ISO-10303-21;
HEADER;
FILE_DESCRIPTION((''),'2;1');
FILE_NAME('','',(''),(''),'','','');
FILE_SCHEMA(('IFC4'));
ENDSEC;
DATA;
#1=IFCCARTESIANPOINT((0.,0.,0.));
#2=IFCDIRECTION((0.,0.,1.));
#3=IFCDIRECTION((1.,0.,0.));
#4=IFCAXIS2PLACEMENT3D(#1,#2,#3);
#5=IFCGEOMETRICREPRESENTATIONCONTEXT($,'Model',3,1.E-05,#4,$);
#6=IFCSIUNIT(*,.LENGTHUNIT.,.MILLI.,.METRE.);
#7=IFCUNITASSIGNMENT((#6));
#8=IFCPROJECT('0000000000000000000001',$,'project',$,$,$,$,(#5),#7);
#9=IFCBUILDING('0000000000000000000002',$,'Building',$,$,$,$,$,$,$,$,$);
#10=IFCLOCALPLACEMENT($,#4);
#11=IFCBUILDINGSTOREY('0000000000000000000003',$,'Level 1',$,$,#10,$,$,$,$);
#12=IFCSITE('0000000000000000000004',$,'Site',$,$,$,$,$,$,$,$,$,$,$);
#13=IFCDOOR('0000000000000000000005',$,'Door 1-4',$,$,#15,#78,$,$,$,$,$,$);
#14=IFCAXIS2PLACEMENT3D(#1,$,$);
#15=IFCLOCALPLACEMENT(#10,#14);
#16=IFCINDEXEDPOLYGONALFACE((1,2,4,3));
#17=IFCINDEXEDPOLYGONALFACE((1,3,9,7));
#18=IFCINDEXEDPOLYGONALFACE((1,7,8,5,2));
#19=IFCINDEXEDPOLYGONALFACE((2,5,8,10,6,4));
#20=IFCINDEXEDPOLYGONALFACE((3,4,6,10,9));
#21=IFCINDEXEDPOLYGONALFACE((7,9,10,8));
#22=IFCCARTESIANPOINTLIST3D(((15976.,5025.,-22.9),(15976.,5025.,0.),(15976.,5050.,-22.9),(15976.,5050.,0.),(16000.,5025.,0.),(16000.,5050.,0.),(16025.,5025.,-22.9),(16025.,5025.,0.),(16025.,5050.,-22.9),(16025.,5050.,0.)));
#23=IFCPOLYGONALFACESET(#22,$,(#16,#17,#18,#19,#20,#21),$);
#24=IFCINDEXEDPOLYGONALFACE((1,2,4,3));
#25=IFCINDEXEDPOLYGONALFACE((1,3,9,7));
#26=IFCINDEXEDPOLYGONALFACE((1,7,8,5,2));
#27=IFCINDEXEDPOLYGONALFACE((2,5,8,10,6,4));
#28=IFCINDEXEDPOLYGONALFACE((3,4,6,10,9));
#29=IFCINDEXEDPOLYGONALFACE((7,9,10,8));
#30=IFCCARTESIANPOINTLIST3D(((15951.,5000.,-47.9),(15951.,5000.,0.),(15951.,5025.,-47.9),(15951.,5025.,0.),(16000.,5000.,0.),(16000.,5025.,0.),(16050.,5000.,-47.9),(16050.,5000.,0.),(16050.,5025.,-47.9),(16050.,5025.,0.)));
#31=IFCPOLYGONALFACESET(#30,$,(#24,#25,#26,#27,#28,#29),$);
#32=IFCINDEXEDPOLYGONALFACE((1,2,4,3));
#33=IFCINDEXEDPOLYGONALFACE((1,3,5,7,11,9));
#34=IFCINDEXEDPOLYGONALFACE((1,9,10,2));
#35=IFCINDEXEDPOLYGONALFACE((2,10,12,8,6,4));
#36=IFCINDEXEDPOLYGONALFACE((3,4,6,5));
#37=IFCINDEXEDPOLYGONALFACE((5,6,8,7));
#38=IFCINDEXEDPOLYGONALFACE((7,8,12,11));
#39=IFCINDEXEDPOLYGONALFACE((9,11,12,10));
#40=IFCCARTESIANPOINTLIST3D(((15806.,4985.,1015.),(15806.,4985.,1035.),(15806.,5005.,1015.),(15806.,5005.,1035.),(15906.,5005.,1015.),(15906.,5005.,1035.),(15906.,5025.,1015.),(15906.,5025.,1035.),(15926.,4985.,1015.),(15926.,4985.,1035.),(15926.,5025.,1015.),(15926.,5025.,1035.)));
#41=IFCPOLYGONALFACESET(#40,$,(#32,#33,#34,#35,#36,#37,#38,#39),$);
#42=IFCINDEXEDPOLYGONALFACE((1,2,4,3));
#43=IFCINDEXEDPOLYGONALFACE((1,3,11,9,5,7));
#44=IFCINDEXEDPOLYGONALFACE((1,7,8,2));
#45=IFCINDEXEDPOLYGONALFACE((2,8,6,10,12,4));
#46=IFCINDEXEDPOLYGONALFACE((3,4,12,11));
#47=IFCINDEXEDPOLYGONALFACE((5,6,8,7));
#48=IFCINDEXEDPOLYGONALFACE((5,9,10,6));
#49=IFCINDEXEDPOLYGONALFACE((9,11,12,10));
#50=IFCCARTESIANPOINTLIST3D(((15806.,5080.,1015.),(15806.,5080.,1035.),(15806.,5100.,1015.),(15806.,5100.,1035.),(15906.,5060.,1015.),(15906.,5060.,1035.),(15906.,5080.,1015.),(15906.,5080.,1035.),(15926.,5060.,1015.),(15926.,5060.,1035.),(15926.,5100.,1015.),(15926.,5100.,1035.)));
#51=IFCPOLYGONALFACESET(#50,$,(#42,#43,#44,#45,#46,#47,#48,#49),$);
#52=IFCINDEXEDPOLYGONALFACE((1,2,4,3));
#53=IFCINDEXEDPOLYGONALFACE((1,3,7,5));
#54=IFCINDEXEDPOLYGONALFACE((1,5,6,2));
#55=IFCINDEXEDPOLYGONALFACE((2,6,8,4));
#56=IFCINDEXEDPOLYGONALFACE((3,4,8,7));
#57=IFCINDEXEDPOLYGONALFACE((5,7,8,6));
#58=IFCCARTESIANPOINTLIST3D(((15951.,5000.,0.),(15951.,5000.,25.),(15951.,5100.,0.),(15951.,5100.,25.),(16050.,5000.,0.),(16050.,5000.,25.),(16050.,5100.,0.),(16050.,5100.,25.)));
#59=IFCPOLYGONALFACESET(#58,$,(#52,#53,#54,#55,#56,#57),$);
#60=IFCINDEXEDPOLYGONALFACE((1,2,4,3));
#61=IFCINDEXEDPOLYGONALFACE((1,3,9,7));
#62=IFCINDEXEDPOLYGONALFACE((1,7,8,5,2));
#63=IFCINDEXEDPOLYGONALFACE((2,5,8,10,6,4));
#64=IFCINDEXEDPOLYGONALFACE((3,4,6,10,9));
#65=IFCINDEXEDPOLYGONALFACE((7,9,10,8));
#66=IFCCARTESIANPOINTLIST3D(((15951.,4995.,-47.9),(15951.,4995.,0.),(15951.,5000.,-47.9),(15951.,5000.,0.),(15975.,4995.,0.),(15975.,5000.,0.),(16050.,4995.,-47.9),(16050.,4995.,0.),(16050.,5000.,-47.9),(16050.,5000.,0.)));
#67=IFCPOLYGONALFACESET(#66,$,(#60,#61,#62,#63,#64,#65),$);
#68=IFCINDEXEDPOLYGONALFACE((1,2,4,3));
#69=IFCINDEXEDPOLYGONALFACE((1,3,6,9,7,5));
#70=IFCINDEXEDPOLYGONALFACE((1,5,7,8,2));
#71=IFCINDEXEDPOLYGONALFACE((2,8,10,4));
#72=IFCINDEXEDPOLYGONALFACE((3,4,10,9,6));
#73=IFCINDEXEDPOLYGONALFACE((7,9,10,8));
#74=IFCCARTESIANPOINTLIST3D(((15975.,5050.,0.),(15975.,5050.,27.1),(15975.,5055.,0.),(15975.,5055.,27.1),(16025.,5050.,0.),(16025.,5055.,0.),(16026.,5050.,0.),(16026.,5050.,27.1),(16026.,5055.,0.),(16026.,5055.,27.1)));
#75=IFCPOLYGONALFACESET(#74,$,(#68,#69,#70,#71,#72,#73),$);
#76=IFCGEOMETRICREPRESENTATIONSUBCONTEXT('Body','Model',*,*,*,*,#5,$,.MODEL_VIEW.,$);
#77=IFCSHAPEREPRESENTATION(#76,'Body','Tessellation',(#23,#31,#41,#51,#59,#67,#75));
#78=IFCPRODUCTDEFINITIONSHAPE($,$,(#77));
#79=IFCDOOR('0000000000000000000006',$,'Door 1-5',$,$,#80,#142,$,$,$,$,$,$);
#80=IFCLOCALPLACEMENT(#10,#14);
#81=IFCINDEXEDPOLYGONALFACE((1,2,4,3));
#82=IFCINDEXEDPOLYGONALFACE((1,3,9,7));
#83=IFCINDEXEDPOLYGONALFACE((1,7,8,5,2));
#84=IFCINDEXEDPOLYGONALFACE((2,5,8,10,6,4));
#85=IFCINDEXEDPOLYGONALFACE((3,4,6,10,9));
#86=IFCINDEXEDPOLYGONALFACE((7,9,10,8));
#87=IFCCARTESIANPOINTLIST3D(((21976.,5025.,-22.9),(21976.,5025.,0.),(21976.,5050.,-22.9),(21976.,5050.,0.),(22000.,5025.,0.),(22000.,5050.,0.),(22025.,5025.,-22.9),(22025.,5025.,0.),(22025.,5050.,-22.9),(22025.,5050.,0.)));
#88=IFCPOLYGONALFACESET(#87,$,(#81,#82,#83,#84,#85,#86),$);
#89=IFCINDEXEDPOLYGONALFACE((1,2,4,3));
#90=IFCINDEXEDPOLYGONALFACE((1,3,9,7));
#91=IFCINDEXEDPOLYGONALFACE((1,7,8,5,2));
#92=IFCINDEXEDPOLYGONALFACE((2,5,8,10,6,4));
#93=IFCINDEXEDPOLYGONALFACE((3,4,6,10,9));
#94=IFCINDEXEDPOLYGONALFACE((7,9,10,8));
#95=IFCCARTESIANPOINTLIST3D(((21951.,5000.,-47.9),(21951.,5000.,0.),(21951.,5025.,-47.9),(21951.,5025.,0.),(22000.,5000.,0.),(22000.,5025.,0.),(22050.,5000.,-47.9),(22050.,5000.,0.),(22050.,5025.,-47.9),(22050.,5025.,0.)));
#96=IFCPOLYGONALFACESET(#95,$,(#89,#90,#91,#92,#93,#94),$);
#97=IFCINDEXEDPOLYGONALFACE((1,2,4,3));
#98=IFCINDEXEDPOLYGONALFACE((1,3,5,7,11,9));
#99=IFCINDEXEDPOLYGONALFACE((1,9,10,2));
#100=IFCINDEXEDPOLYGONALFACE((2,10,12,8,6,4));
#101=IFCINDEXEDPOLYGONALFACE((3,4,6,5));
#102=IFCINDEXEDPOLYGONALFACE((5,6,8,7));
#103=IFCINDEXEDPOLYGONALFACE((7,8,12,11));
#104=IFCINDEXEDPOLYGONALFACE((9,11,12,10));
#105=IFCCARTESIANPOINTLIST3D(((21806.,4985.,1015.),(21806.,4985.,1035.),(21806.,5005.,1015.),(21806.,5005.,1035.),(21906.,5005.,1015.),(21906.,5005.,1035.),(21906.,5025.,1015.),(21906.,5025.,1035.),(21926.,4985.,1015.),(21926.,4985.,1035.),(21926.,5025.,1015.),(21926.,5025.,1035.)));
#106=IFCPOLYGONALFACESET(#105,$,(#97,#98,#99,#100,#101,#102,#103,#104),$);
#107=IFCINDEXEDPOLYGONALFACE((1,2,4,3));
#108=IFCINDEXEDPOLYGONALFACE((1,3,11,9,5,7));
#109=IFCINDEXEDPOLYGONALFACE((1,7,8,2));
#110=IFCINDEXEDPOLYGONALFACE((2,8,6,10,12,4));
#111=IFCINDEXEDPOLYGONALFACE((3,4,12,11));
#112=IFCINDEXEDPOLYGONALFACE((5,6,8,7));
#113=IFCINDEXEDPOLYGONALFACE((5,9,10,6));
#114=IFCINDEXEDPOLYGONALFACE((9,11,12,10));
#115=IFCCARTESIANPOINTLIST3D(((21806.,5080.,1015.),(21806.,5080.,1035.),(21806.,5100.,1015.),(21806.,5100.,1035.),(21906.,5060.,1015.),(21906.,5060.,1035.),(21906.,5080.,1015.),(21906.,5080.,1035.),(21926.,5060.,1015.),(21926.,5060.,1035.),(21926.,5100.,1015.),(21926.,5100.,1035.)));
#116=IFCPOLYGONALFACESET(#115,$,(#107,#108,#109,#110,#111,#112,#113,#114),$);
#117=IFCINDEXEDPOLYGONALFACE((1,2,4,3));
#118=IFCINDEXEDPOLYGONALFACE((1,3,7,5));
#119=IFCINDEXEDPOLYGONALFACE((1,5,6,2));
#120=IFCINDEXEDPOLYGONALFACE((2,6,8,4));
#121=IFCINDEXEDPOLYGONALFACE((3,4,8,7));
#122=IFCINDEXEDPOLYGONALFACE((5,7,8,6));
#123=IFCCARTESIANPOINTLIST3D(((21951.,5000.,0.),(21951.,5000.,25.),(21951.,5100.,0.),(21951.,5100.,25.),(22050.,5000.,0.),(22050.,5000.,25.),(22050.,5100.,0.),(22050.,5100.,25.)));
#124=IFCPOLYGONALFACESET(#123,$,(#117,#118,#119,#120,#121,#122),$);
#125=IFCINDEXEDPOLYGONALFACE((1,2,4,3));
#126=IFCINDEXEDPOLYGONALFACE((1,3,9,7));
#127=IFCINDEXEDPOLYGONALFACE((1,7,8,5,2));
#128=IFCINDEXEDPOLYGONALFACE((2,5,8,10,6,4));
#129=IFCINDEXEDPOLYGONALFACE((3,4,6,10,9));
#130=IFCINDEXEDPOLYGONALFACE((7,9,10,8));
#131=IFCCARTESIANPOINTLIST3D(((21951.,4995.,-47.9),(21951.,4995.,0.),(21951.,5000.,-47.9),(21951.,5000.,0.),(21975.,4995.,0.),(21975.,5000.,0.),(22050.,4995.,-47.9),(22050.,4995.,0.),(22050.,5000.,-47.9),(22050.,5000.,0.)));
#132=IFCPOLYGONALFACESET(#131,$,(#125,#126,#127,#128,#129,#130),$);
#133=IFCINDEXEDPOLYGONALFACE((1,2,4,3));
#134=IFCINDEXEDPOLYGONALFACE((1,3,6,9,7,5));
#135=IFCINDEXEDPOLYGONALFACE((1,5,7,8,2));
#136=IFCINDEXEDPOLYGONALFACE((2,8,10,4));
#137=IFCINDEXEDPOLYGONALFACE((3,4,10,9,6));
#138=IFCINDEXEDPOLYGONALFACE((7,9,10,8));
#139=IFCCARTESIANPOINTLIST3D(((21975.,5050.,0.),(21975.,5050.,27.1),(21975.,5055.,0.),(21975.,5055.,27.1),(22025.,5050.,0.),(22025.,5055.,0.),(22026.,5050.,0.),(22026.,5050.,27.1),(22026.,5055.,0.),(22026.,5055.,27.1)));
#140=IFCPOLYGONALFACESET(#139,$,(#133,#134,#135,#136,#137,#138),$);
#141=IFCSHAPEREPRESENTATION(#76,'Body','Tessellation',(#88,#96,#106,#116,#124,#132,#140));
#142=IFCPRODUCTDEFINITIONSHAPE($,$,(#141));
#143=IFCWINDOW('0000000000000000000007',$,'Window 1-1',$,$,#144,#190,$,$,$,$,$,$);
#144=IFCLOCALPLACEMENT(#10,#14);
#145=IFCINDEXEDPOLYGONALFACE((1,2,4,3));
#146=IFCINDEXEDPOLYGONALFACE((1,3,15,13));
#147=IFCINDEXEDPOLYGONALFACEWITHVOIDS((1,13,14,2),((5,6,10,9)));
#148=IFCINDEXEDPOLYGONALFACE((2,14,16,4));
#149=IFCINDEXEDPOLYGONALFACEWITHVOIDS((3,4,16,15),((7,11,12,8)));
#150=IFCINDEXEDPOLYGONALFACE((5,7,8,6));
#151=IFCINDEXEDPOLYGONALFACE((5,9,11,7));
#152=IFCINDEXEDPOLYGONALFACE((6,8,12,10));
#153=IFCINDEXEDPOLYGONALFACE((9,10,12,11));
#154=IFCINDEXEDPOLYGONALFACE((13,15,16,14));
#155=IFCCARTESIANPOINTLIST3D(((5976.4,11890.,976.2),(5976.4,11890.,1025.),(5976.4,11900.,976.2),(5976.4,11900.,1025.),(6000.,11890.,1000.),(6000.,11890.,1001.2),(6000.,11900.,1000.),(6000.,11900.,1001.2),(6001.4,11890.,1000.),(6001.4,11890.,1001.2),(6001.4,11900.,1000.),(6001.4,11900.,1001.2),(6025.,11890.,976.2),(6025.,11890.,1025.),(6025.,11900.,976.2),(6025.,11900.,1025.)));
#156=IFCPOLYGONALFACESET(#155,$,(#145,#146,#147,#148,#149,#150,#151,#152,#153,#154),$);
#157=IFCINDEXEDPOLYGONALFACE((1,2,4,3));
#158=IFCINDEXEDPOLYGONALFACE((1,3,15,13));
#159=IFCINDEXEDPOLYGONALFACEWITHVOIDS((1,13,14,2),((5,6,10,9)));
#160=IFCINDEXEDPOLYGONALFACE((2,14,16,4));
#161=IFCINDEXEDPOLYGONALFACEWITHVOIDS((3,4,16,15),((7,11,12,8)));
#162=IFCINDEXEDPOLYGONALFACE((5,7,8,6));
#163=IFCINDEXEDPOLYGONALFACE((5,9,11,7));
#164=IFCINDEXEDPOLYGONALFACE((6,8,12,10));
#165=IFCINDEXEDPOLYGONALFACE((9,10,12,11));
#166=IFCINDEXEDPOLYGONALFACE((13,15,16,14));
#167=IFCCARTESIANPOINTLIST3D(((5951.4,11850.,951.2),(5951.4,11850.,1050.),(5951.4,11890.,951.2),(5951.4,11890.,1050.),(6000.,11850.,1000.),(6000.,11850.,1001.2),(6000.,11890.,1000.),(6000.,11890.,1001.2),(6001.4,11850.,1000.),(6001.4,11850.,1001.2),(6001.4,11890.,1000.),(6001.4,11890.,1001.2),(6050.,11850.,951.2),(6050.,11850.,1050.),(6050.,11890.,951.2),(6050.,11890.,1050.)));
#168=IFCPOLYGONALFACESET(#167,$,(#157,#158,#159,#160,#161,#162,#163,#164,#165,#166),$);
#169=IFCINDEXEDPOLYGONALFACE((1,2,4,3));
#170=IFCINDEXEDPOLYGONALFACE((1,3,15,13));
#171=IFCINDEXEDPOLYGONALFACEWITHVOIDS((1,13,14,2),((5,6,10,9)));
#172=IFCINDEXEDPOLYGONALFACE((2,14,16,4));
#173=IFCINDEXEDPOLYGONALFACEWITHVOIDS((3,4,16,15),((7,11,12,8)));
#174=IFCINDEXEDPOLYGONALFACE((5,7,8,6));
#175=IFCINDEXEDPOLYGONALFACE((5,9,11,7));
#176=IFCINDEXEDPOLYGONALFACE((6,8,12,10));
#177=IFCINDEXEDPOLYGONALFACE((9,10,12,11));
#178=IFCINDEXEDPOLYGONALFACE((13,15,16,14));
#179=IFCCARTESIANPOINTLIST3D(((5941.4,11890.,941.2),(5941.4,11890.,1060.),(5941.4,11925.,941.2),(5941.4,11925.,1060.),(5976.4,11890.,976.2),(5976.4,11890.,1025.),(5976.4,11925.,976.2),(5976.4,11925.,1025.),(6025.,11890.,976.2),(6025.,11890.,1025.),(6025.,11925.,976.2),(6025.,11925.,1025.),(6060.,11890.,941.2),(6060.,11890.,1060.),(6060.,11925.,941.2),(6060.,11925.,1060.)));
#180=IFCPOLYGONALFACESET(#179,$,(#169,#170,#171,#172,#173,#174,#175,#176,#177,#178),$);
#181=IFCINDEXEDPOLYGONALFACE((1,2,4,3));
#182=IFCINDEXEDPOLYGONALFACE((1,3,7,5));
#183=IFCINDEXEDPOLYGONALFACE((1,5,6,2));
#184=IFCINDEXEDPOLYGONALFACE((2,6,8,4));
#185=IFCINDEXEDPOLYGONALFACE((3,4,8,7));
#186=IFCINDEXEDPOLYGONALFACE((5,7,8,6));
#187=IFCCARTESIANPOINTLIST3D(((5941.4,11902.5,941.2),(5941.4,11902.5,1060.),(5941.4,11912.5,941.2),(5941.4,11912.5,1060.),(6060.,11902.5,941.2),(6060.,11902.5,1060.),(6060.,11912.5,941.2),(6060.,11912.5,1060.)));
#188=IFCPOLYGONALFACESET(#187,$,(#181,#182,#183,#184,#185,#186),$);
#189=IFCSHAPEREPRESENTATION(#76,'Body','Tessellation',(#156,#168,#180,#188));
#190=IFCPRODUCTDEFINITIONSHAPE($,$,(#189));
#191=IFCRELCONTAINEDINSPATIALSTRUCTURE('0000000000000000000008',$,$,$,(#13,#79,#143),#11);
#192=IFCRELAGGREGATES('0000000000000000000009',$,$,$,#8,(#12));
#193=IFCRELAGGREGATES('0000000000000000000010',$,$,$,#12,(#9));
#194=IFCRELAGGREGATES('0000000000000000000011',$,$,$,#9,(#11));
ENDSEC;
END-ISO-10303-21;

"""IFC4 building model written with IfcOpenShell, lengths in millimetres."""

from ifc_helpers import new_model, si_unit, frame, origin_with_axes, place, context, subcontext, project, spatial, line, indexed_curve, outline, extrude, element, save


model = new_model("IFC4")

# Units and contexts
model_context = context("Model", 3, precision=1e-05, world=origin_with_axes())
body_context = subcontext(model_context, "Body", "Model", "MODEL_VIEW")
ifc_project = project(units=[si_unit("LENGTHUNIT", "METRE", prefix="MILLI")], contexts=[model_context])

# Site, building, storey
site = spatial("IfcSite", under=ifc_project, Name="Site")
building = spatial("IfcBuilding", under=site, Name="Building")
storey_placement = place(None, origin_with_axes())
storey = spatial("IfcBuildingStorey", under=building, at=storey_placement, Name="Level 1")

# Doors
door_1_placement = place(storey_placement, frame((16000.0, 5000.0, 0.0), z_axis=(0.0, 0.0, 1.0), x_axis=(1.0, 0.0, 0.0)))
element("IfcDoor", 1, at=door_1_placement, inside=storey, Name="Door 1-4", context=body_context, shape_type="SweptSolid", body=[
    extrude(outline(indexed_curve([(0.0, 0.0), (0.0, 2.1), (1.0, 2.1), (1.0, 0.0), (-24.0, 0.0), (-24.0, -22.9), (25.0, -22.9), (25.0, 0.0)], segments=[line(1, 2, 3, 4, 5, 6, 7, 8, 1)])), frame((0.0, 25.0, 0.0), z_axis=(0.0, -1.0, 0.0), x_axis=(1.0, 0.0, 0.0)), (0.0, 0.0, -1.0), 25.0),
    extrude(outline(indexed_curve([(0.0, 0.0), (0.0, 2.1), (1.0, 2.1), (1.0, 0.0), (-49.0, 0.0), (-49.0, -47.9), (50.0, -47.9), (50.0, 0.0)], segments=[line(1, 2, 3, 4, 5, 6, 7, 8, 1)])), frame((0.0, 0.0, 0.0), z_axis=(0.0, -1.0, 0.0), x_axis=(1.0, 0.0, 0.0)), (0.0, 0.0, -1.0), 25.0),
    extrude(outline(indexed_curve([(0.0, 0.0), (-49.0, 0.0), (-49.0, 35.0), (0.0, 35.0)], segments=[line(1, 2, 3, 4, 1)])), frame((25.0, 25.0, 25.0), z_axis=(0.0, 0.0, 1.0), x_axis=(1.0, 0.0, 0.0)), (0.0, 0.0, 1.0), -47.9),
    extrude(outline(indexed_curve([(0.0, 0.0), (0.0, -40.0), (-120.0, -40.0), (-120.0, -20.0), (-20.0, -20.0), (-20.0, 0.0)], segments=[line(1, 2, 3, 4, 5, 6, 1)])), frame((-74.0, 25.0, 1015.0), z_axis=(0.0, 0.0, 1.0), x_axis=(1.0, 0.0, 0.0)), (0.0, 0.0, 1.0), 20.0),
    extrude(outline(indexed_curve([(0.0, 0.0), (0.0, 40.0), (-120.0, 40.0), (-120.0, 20.0), (-20.0, 20.0), (-20.0, 0.0)], segments=[line(1, 2, 3, 4, 5, 6, 1)])), frame((-74.0, 60.0, 1015.0), z_axis=(0.0, 0.0, 1.0), x_axis=(1.0, 0.0, 0.0)), (0.0, 0.0, 1.0), 20.0),
    extrude(outline(indexed_curve([(0.0, 0.0), (-99.0, 0.0), (-99.0, 100.0), (0.0, 100.0)], segments=[line(1, 2, 3, 4, 1)])), frame((50.0, 0.0, 0.0), z_axis=(0.0, 0.0, 1.0), x_axis=(1.0, 0.0, 0.0)), (0.0, 0.0, 1.0), 25.0),
    extrude(outline(indexed_curve([(0.0, 0.0), (0.0, 27.1), (51.0, 27.1), (51.0, 0.0), (-24.0, 0.0), (-24.0, -47.9), (75.0, -47.9), (75.0, 0.0)], segments=[line(1, 2, 3, 4, 5, 6, 7, 8, 1)])), frame((-25.0, -5.0, 0.0), z_axis=(0.0, -1.0, 0.0), x_axis=(1.0, 0.0, 0.0)), (0.0, 0.0, -1.0), 5.0),
    extrude(outline(indexed_curve([(0.0, 0.0), (0.0, 27.1), (51.0, 27.1), (51.0, 0.0), (1.0, 0.0), (1.0, -22.9), (50.0, -22.9), (50.0, 0.0)], segments=[line(1, 2, 3, 4, 5, 6, 7, 8, 1)])), frame((-25.0, 50.0, 0.0), z_axis=(0.0, -1.0, 0.0), x_axis=(1.0, 0.0, 0.0)), (0.0, 0.0, -1.0), 5.0),
])
door_2_placement = place(storey_placement, frame((22000.0, 5000.0, 0.0), z_axis=(0.0, 0.0, 1.0), x_axis=(1.0, 0.0, 0.0)))
element("IfcDoor", 2, at=door_2_placement, inside=storey, Name="Door 1-5", context=body_context, shape_type="SweptSolid", body=[
    extrude(outline(indexed_curve([(0.0, 0.0), (0.0, 2.1), (1.0, 2.1), (1.0, 0.0), (-24.0, 0.0), (-24.0, -22.9), (25.0, -22.9), (25.0, 0.0)], segments=[line(1, 2, 3, 4, 5, 6, 7, 8, 1)])), frame((0.0, 25.0, 0.0), z_axis=(0.0, -1.0, 0.0), x_axis=(1.0, 0.0, 0.0)), (0.0, 0.0, -1.0), 25.0),
    extrude(outline(indexed_curve([(0.0, 0.0), (0.0, 2.1), (1.0, 2.1), (1.0, 0.0), (-49.0, 0.0), (-49.0, -47.9), (50.0, -47.9), (50.0, 0.0)], segments=[line(1, 2, 3, 4, 5, 6, 7, 8, 1)])), frame((0.0, 0.0, 0.0), z_axis=(0.0, -1.0, 0.0), x_axis=(1.0, 0.0, 0.0)), (0.0, 0.0, -1.0), 25.0),
    extrude(outline(indexed_curve([(0.0, 0.0), (-49.0, 0.0), (-49.0, 35.0), (0.0, 35.0)], segments=[line(1, 2, 3, 4, 1)])), frame((25.0, 25.0, 25.0), z_axis=(0.0, 0.0, 1.0), x_axis=(1.0, 0.0, 0.0)), (0.0, 0.0, 1.0), -47.9),
    extrude(outline(indexed_curve([(0.0, 0.0), (0.0, -40.0), (-120.0, -40.0), (-120.0, -20.0), (-20.0, -20.0), (-20.0, 0.0)], segments=[line(1, 2, 3, 4, 5, 6, 1)])), frame((-74.0, 25.0, 1015.0), z_axis=(0.0, 0.0, 1.0), x_axis=(1.0, 0.0, 0.0)), (0.0, 0.0, 1.0), 20.0),
    extrude(outline(indexed_curve([(0.0, 0.0), (0.0, 40.0), (-120.0, 40.0), (-120.0, 20.0), (-20.0, 20.0), (-20.0, 0.0)], segments=[line(1, 2, 3, 4, 5, 6, 1)])), frame((-74.0, 60.0, 1015.0), z_axis=(0.0, 0.0, 1.0), x_axis=(1.0, 0.0, 0.0)), (0.0, 0.0, 1.0), 20.0),
    extrude(outline(indexed_curve([(0.0, 0.0), (-99.0, 0.0), (-99.0, 100.0), (0.0, 100.0)], segments=[line(1, 2, 3, 4, 1)])), frame((50.0, 0.0, 0.0), z_axis=(0.0, 0.0, 1.0), x_axis=(1.0, 0.0, 0.0)), (0.0, 0.0, 1.0), 25.0),
    extrude(outline(indexed_curve([(0.0, 0.0), (0.0, 27.1), (51.0, 27.1), (51.0, 0.0), (-24.0, 0.0), (-24.0, -47.9), (75.0, -47.9), (75.0, 0.0)], segments=[line(1, 2, 3, 4, 5, 6, 7, 8, 1)])), frame((-25.0, -5.0, 0.0), z_axis=(0.0, -1.0, 0.0), x_axis=(1.0, 0.0, 0.0)), (0.0, 0.0, -1.0), 5.0),
    extrude(outline(indexed_curve([(0.0, 0.0), (0.0, 27.1), (51.0, 27.1), (51.0, 0.0), (1.0, 0.0), (1.0, -22.9), (50.0, -22.9), (50.0, 0.0)], segments=[line(1, 2, 3, 4, 5, 6, 7, 8, 1)])), frame((-25.0, 50.0, 0.0), z_axis=(0.0, -1.0, 0.0), x_axis=(1.0, 0.0, 0.0)), (0.0, 0.0, -1.0), 5.0),
])

# Window
for number, where, z_axis, x_axis, name in (
    (3, (6000.0, 11800.0, 1000.0), (0.0, 0.0, 1.0), (1.0, 0.0, 0.0), "Window 1-1"),
):
    element("IfcWindow", number, at=place(storey_placement, frame(where, z_axis=z_axis, x_axis=x_axis)), inside=storey, Name=name, context=body_context, shape_type="SweptSolid", body=[
        extrude(outline(indexed_curve([(0.0, 0.0), (1.4, 0.0), (1.4, 1.2), (0.0, 1.2)], segments=[line(1, 2, 3, 4, 1)]), holes=[indexed_curve([(25.0, 25.0), (-23.6, 25.0), (-23.6, -23.8), (25.0, -23.8)], segments=[line(1, 2, 3, 4, 1)])]), frame((0.0, 90.0, 0.0), z_axis=(0.0, -1.0, 0.0), x_axis=(1.0, 0.0, 0.0)), (0.0, 0.0, -1.0), 10.0),
        extrude(outline(indexed_curve([(0.0, 0.0), (1.4, 0.0), (1.4, 1.2), (0.0, 1.2)], segments=[line(1, 2, 3, 4, 1)]), holes=[indexed_curve([(50.0, 50.0), (-48.6, 50.0), (-48.6, -48.8), (50.0, -48.8)], segments=[line(1, 2, 3, 4, 1)])]), frame((0.0, 50.0, 0.0), z_axis=(0.0, -1.0, 0.0), x_axis=(1.0, 0.0, 0.0)), (0.0, 0.0, -1.0), 40.0),
        extrude(outline(indexed_curve([(0.0, 0.0), (-48.6, 0.0), (-48.6, -48.8), (0.0, -48.8)], segments=[line(1, 2, 3, 4, 1)]), holes=[indexed_curve([(35.0, 35.0), (-83.6, 35.0), (-83.6, -83.8), (35.0, -83.8)], segments=[line(1, 2, 3, 4, 1)])]), frame((25.0, 90.0, 25.0), z_axis=(0.0, -1.0, 0.0), x_axis=(1.0, 0.0, 0.0)), (0.0, 0.0, -1.0), 35.0),
        extrude(outline(indexed_curve([(35.0, 35.0), (-83.6, 35.0), (-83.6, -83.8), (35.0, -83.8)], segments=[line(1, 2, 3, 4, 1)])), frame((25.0, 102.5, 25.0), z_axis=(0.0, -1.0, 0.0), x_axis=(1.0, 0.0, 0.0)), (0.0, 0.0, -1.0), 10.0),
    ])

save(model, "model.ifc")
